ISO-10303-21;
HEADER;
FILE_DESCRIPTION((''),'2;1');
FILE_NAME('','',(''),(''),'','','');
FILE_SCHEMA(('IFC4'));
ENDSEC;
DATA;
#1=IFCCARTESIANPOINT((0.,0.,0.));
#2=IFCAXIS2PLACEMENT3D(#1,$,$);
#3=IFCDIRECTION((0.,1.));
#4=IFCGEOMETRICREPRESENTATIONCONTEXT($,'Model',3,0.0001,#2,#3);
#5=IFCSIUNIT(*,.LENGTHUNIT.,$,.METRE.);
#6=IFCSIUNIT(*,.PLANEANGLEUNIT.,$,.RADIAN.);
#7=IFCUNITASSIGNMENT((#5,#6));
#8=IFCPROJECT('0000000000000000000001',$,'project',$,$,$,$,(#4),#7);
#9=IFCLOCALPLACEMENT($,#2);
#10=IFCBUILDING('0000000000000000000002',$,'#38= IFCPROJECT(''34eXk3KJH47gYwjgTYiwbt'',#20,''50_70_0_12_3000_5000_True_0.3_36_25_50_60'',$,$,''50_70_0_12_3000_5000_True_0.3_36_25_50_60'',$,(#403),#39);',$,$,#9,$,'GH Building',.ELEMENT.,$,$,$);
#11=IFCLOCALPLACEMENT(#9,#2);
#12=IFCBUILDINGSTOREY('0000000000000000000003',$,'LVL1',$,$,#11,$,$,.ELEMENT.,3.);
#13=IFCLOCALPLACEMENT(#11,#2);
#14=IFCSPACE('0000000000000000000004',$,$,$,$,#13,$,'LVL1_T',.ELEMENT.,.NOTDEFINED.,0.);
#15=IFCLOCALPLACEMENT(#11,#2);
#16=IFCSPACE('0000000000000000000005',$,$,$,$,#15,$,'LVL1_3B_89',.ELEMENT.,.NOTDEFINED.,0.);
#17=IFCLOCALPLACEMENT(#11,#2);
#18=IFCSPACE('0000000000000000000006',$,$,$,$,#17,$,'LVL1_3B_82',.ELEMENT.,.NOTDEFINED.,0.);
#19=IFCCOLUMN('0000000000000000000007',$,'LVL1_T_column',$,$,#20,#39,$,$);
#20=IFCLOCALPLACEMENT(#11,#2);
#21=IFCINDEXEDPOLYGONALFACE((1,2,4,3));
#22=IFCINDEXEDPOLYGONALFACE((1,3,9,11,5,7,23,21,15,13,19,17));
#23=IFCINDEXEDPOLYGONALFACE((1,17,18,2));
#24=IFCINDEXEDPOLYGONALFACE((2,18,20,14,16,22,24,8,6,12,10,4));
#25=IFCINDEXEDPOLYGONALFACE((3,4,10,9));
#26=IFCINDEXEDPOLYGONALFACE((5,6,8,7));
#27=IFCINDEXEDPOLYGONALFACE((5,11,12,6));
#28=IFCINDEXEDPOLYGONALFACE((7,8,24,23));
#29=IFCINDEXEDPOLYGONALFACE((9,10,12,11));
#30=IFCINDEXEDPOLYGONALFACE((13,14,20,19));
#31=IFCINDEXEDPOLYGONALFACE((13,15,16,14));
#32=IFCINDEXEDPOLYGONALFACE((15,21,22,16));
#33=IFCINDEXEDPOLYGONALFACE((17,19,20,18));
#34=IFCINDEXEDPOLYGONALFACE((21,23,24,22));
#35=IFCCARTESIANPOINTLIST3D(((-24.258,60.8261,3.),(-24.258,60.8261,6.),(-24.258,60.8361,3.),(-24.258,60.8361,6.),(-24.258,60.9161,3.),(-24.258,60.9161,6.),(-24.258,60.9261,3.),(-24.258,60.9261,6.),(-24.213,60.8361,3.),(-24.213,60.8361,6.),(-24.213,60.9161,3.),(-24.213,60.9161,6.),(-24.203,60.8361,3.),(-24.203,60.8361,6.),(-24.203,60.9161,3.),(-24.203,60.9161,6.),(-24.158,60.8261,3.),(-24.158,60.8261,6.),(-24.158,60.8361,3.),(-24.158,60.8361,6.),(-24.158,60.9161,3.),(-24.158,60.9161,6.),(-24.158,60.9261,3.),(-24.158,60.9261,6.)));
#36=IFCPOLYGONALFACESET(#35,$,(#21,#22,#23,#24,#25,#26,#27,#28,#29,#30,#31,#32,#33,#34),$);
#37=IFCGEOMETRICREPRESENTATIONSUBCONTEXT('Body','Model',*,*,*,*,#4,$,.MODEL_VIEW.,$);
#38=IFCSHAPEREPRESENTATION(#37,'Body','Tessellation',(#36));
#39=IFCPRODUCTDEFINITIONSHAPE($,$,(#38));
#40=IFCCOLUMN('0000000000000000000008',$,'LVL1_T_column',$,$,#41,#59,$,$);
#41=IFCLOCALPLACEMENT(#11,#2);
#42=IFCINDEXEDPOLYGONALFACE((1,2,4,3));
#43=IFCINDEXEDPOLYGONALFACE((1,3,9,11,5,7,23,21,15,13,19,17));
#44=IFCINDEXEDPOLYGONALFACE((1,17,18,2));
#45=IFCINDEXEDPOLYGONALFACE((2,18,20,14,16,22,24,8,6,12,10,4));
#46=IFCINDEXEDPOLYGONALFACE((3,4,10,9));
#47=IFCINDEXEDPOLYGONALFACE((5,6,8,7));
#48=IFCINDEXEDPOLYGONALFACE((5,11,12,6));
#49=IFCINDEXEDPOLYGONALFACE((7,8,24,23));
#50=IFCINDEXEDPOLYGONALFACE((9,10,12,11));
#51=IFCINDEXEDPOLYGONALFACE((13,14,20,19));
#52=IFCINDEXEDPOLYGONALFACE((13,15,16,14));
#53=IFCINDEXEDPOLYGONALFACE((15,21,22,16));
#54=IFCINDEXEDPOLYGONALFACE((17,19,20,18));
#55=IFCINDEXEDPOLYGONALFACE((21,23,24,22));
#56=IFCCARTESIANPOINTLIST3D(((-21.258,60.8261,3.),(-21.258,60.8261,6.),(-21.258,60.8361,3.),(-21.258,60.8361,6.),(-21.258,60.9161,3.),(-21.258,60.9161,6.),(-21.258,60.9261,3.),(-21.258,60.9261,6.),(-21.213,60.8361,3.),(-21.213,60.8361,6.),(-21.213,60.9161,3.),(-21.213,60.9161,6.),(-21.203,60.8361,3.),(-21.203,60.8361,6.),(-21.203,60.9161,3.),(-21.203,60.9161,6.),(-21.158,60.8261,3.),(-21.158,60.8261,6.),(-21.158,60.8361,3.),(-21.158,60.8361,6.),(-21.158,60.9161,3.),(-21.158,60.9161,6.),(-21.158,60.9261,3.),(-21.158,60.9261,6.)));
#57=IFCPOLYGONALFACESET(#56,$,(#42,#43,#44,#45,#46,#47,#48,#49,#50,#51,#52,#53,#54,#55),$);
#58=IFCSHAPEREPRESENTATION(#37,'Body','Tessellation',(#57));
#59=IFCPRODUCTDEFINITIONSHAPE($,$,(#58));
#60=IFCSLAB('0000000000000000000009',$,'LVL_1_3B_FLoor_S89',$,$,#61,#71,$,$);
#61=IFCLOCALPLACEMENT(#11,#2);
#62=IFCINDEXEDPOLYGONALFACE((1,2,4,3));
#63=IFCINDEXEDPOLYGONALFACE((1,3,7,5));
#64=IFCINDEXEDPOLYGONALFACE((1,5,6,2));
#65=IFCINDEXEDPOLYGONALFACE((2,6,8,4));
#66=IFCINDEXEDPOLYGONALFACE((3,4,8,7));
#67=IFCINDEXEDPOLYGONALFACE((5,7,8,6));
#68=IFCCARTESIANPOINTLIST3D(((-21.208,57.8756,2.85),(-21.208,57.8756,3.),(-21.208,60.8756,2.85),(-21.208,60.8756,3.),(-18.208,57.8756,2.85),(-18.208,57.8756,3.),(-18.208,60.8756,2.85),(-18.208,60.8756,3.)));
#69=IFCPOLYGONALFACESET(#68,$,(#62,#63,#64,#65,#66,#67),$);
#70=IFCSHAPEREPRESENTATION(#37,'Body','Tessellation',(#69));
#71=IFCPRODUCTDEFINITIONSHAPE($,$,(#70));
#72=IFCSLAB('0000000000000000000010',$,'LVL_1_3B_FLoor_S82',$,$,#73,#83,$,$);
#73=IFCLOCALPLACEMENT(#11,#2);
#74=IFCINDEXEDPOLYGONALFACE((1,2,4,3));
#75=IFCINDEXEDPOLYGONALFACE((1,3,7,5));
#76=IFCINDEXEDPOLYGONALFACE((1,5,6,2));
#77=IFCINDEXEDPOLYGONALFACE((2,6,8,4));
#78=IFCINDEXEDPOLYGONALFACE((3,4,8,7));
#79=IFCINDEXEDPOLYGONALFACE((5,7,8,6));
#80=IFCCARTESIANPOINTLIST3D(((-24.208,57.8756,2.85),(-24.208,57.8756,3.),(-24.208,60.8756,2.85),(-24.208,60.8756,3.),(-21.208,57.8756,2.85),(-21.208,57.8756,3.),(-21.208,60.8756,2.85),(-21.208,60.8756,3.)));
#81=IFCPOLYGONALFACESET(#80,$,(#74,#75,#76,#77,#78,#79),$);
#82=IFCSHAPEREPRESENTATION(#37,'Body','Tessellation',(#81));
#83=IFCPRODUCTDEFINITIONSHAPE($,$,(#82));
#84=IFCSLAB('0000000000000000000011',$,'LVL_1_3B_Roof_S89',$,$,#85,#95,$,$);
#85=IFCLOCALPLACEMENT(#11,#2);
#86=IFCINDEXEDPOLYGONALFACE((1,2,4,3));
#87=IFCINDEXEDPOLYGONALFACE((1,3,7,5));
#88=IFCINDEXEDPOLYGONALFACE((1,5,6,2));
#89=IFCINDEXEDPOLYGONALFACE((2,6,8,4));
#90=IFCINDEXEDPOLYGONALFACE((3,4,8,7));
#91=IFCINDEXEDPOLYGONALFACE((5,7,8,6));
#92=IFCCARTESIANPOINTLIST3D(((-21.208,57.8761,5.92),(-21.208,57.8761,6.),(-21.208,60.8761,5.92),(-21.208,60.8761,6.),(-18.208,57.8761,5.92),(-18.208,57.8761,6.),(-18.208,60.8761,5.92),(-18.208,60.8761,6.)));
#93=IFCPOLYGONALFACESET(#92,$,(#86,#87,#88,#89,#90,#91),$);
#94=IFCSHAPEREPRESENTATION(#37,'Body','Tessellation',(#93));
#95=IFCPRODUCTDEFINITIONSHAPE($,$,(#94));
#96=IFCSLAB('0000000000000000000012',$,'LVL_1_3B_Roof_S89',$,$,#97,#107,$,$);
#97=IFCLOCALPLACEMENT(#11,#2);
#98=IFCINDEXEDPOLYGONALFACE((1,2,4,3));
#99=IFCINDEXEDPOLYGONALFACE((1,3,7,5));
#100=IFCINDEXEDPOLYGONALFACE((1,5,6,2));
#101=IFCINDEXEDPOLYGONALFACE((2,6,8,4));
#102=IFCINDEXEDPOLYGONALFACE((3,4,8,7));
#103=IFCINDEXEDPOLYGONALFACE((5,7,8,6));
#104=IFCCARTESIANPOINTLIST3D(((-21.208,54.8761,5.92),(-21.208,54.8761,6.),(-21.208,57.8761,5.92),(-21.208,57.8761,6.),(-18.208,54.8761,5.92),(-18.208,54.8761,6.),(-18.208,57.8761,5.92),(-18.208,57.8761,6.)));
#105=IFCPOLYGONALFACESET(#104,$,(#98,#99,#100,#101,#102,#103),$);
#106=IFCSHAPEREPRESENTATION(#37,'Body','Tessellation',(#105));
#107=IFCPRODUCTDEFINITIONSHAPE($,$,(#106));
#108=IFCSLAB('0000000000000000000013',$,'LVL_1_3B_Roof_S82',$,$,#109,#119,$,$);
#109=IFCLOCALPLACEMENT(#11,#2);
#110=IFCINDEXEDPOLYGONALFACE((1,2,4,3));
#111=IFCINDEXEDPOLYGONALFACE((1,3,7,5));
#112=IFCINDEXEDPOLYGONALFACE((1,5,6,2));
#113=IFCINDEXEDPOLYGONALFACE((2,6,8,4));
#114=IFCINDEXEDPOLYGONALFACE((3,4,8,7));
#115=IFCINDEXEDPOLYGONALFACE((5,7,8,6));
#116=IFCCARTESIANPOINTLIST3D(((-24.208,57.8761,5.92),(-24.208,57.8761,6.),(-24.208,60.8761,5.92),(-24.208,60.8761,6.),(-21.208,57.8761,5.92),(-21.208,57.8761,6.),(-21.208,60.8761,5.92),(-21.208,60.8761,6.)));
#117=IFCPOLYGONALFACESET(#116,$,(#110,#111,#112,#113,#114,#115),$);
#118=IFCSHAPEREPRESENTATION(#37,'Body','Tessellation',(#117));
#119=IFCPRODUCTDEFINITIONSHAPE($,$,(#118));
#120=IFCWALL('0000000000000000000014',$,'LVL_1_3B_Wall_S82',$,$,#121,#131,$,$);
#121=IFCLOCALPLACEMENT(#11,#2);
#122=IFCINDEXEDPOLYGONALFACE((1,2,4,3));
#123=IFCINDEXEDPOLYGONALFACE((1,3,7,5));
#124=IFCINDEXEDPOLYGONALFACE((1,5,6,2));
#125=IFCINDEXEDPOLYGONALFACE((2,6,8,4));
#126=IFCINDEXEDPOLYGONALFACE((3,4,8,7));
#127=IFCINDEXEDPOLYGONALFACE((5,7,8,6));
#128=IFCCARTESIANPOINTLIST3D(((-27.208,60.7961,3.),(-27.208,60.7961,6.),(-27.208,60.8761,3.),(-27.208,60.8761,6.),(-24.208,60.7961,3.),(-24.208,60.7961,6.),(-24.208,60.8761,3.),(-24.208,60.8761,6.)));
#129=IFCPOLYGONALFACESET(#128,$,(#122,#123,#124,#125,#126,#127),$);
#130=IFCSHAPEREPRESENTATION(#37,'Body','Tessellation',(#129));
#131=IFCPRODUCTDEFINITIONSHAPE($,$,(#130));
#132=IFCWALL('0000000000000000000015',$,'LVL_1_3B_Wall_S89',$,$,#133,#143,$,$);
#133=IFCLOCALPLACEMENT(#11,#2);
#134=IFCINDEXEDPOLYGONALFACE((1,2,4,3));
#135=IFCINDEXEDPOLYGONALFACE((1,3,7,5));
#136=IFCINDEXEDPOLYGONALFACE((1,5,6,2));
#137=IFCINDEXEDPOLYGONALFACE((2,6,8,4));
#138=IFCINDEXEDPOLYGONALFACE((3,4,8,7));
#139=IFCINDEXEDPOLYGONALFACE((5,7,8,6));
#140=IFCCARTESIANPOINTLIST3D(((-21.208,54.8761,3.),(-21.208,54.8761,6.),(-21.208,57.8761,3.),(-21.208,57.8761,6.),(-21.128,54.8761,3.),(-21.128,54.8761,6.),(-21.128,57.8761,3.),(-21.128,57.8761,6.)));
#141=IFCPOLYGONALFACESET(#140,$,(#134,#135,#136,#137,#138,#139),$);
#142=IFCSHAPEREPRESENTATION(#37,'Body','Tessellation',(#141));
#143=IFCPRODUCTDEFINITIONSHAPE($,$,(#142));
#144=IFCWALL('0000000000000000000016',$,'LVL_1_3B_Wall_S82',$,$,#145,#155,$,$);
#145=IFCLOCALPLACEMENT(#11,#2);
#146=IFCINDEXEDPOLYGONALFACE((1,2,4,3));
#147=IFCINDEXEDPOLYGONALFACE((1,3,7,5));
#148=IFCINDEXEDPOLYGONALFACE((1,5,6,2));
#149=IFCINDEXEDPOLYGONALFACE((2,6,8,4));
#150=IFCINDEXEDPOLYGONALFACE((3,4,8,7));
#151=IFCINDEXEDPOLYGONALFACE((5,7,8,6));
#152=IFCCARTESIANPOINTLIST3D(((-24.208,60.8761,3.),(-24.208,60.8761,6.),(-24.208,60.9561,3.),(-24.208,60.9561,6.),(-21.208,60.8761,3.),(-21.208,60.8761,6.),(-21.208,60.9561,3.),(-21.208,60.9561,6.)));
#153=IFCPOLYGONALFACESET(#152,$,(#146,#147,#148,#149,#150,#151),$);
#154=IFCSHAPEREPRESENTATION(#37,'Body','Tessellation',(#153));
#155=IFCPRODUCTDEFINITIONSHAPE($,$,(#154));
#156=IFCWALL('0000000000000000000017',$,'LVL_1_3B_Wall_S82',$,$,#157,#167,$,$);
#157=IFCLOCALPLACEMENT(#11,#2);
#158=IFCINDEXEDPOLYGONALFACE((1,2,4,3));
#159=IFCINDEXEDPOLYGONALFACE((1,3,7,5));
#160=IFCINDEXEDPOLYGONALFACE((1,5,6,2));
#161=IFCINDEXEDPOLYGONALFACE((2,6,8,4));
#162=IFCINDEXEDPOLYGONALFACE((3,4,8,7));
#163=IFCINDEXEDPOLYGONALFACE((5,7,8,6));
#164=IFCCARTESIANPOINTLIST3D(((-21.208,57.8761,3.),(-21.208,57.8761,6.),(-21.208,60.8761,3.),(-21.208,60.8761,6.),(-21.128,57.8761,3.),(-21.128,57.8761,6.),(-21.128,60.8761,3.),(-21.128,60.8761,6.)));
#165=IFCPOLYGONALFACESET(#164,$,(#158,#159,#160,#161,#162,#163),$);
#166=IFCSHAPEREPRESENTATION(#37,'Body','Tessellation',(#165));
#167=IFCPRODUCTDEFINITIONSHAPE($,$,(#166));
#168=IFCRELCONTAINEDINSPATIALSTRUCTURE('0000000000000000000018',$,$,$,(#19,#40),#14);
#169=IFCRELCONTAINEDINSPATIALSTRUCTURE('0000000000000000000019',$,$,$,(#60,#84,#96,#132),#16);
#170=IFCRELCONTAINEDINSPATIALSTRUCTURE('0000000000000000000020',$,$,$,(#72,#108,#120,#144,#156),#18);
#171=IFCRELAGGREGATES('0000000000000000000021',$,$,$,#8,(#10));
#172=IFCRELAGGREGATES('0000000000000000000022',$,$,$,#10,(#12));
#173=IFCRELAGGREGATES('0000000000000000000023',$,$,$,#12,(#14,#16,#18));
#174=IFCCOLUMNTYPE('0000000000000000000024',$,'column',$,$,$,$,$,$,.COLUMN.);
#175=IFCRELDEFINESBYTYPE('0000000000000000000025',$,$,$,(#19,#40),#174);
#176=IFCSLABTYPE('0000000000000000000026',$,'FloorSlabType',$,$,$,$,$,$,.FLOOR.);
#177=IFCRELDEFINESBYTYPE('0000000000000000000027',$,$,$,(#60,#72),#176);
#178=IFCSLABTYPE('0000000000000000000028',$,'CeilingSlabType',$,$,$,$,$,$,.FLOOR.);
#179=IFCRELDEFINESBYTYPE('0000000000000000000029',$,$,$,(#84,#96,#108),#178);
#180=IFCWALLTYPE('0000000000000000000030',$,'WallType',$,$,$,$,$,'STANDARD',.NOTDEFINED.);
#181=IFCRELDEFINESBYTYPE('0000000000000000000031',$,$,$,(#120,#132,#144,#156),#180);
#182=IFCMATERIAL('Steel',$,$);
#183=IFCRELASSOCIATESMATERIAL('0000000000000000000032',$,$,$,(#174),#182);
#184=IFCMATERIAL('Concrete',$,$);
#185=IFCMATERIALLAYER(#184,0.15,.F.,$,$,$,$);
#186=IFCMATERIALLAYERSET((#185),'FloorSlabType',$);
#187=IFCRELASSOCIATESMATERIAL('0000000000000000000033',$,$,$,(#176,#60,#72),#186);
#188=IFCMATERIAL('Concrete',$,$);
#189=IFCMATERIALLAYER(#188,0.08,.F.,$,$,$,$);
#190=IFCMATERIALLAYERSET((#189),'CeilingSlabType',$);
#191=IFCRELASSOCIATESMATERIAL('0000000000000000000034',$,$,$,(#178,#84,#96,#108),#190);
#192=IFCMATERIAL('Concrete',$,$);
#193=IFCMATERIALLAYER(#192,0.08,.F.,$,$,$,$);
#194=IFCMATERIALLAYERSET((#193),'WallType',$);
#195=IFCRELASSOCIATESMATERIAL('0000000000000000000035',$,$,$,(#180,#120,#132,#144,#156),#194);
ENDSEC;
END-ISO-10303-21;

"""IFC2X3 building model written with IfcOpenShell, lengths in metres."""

from ifc_helpers import new_model, si_unit, direction, frame, frame_2d, origin, origin_2d, place, context, subcontext, project, spatial, rectangle, i_section, extrude, material, layer, layer_set, layer_usage, type_object, element, save


model = new_model("IFC2X3")

# Units and contexts
model_context = context("Model", 3, precision=0.0001, world=origin(), true_north=direction((0.0, 1.0)))
body_context = subcontext(model_context, "Body", "Model", "MODEL_VIEW")
ifc_project = project(units=[si_unit("LENGTHUNIT", "METRE"), si_unit("PLANEANGLEUNIT", "RADIAN")], contexts=[model_context])

# Building, storey, space
building_placement = place(None, origin())
building = spatial("IfcBuilding", under=ifc_project, at=building_placement, Name="#38= IFCPROJECT('34eXk3KJH47gYwjgTYiwbt',#20,'50_70_0_12_3000_5000_True_0.3_36_25_50_60',$,$,'50_70_0_12_3000_5000_True_0.3_36_25_50_60',$,(#403),#39);", LongName="GH Building", CompositionType="ELEMENT")
storey_placement = place(building_placement, origin())
storey = spatial("IfcBuildingStorey", under=building, at=storey_placement, Name="LVL1", CompositionType="ELEMENT", Elevation=3.0)
space_1_placement = place(storey_placement, origin())
space_1 = spatial("IfcSpace", under=storey, at=space_1_placement, LongName="LVL1_T", CompositionType="ELEMENT", InteriorOrExteriorSpace="NOTDEFINED", ElevationWithFlooring=0.0)

# Columns
ifc_material_1 = material(Name="Steel")
column_type = type_object("IfcColumnType", Name="column", PredefinedType="COLUMN", material=ifc_material_1)
for number, where, name in (
    (1, (-24.208, 60.8761, 3.0), "LVL1_T_column"),
    (2, (-21.208, 60.8761, 3.0), "LVL1_T_column"),
):
    element("IfcColumn", number, at=place(space_1_placement, frame(where)), inside=space_1, type_object=column_type, Name=name, context=body_context, shape_type="SweptSolid", body=[
        extrude(i_section(OverallWidth=0.1, OverallDepth=0.1, WebThickness=0.01, FlangeThickness=0.01, at=origin_2d()), origin(), (0.0, 0.0, 1.0), 3.0),
    ])

# Shared definitions
space_2_placement = place(storey_placement, origin())
space_2 = spatial("IfcSpace", under=storey, at=space_2_placement, LongName="LVL1_3B_89", CompositionType="ELEMENT", InteriorOrExteriorSpace="NOTDEFINED", ElevationWithFlooring=0.0)

# Slab
ifc_material_2 = material(Name="Concrete")
ifc_layer_1 = layer(ifc_material_2, 0.15, ventilated=False)
ifc_layer_set_1 = layer_set([ifc_layer_1], Name="FloorSlabType")
ifc_layer_usage_1 = layer_usage(ifc_layer_set_1, "AXIS3", "NEGATIVE", -0.15)
slab_type_1 = type_object("IfcSlabType", Name="FloorSlabType", PredefinedType="FLOOR", material=ifc_layer_set_1)
slab_1_placement = place(space_2_placement, frame((-21.208, 57.8756, 2.85)))
element("IfcSlab", 3, at=slab_1_placement, inside=space_2, type_object=slab_type_1, material=ifc_layer_usage_1, Name="LVL_1_3B_FLoor_S89", context=body_context, shape_type="SweptSolid", body=[
    extrude(rectangle(XDim=3.0, YDim=3.0, at=frame_2d((1.5, 1.5))), origin(), (0.0, 0.0, 1.0), 0.15),
])

# Shared definitions
space_3_placement = place(storey_placement, origin())
space_3 = spatial("IfcSpace", under=storey, at=space_3_placement, LongName="LVL1_3B_82", CompositionType="ELEMENT", InteriorOrExteriorSpace="NOTDEFINED", ElevationWithFlooring=0.0)

# Slabs
ifc_layer_usage_2 = layer_usage(ifc_layer_set_1, "AXIS3", "NEGATIVE", -0.15)
slab_2_placement = place(space_3_placement, frame((-24.208, 57.8756, 2.85)))
element("IfcSlab", 4, at=slab_2_placement, inside=space_3, type_object=slab_type_1, material=ifc_layer_usage_2, Name="LVL_1_3B_FLoor_S82", context=body_context, shape_type="SweptSolid", body=[
    extrude(rectangle(XDim=3.0, YDim=3.0, at=frame_2d((1.5, 1.5))), origin(), (0.0, 0.0, 1.0), 0.15),
])
ifc_material_3 = material(Name="Concrete")
ifc_layer_2 = layer(ifc_material_3, 0.08, ventilated=False)
ifc_layer_set_2 = layer_set([ifc_layer_2], Name="CeilingSlabType")
ifc_layer_usage_3 = layer_usage(ifc_layer_set_2, "AXIS3", "NEGATIVE", -0.08)
slab_type_2 = type_object("IfcSlabType", Name="CeilingSlabType", PredefinedType="FLOOR", material=ifc_layer_set_2)
slab_3_placement = place(space_2_placement, frame((-21.208, 57.8761, 5.92)))
element("IfcSlab", 5, at=slab_3_placement, inside=space_2, type_object=slab_type_2, material=ifc_layer_usage_3, Name="LVL_1_3B_Roof_S89", context=body_context, shape_type="SweptSolid", body=[
    extrude(rectangle(XDim=3.0, YDim=3.0, at=frame_2d((1.5, 1.5))), origin(), (0.0, 0.0, 1.0), 0.08),
])
ifc_layer_usage_4 = layer_usage(ifc_layer_set_2, "AXIS3", "NEGATIVE", -0.08)
slab_4_placement = place(space_2_placement, frame((-21.208, 54.8761, 5.92)))
element("IfcSlab", 6, at=slab_4_placement, inside=space_2, type_object=slab_type_2, material=ifc_layer_usage_4, Name="LVL_1_3B_Roof_S89", context=body_context, shape_type="SweptSolid", body=[
    extrude(rectangle(XDim=3.0, YDim=3.0, at=frame_2d((1.5, 1.5))), origin(), (0.0, 0.0, 1.0), 0.08),
])
ifc_layer_usage_5 = layer_usage(ifc_layer_set_2, "AXIS3", "NEGATIVE", -0.08)
slab_5_placement = place(space_3_placement, frame((-21.208, 57.8761, 5.92), z_axis=(0.0, 0.0, 1.0), x_axis=(-1.0, 0.0, 0.0)))
element("IfcSlab", 7, at=slab_5_placement, inside=space_3, type_object=slab_type_2, material=ifc_layer_usage_5, Name="LVL_1_3B_Roof_S82", context=body_context, shape_type="SweptSolid", body=[
    extrude(rectangle(XDim=3.0, YDim=3.0, at=frame_2d((1.5, -1.5))), origin(), (0.0, 0.0, 1.0), 0.08),
])

# Shared definitions
ifc_material_4 = material(Name="Concrete")
ifc_layer_3 = layer(ifc_material_4, 0.08, ventilated=False)
ifc_layer_set_3 = layer_set([ifc_layer_3], Name="WallType")
wall_type = type_object("IfcWallType", Name="WallType", ElementType="STANDARD", PredefinedType="NOTDEFINED", material=ifc_layer_set_3)

# Walls
ifc_layer_usage_6 = layer_usage(ifc_layer_set_3, "AXIS2", "NEGATIVE", 0.0)
wall_1_placement = place(space_3_placement, frame((-27.208, 60.8761, 3.0)))
element("IfcWall", 8, at=wall_1_placement, inside=space_3, type_object=wall_type, material=ifc_layer_usage_6, Name="LVL_1_3B_Wall_S82", context=body_context, shape_type="SweptSolid", body=[
    extrude(rectangle(XDim=3.0, YDim=0.08, at=frame_2d((1.5, -0.04))), origin(), (0.0, 0.0, 1.0), 3.0),
])
ifc_layer_usage_7 = layer_usage(ifc_layer_set_3, "AXIS2", "NEGATIVE", 0.0)
wall_2_placement = place(space_2_placement, frame((-21.208, 54.8761, 3.0), z_axis=(0.0, 0.0, 1.0), x_axis=(0.0, 1.0, 0.0)))
element("IfcWall", 9, at=wall_2_placement, inside=space_2, type_object=wall_type, material=ifc_layer_usage_7, Name="LVL_1_3B_Wall_S89", context=body_context, shape_type="SweptSolid", body=[
    extrude(rectangle(XDim=3.0, YDim=0.08, at=frame_2d((1.5, -0.04))), origin(), (0.0, 0.0, 1.0), 3.0),
])
ifc_layer_usage_8 = layer_usage(ifc_layer_set_3, "AXIS2", "NEGATIVE", 0.0)
wall_3_placement = place(space_3_placement, frame((-21.208, 60.8761, 3.0), z_axis=(0.0, 0.0, 1.0), x_axis=(-1.0, 0.0, 0.0)))
element("IfcWall", 10, at=wall_3_placement, inside=space_3, type_object=wall_type, material=ifc_layer_usage_8, Name="LVL_1_3B_Wall_S82", context=body_context, shape_type="SweptSolid", body=[
    extrude(rectangle(XDim=3.0, YDim=0.08, at=frame_2d((1.5, -0.04))), origin(), (0.0, 0.0, 1.0), 3.0),
])
ifc_layer_usage_9 = layer_usage(ifc_layer_set_3, "AXIS2", "NEGATIVE", 0.0)
wall_4_placement = place(space_3_placement, frame((-21.208, 57.8761, 3.0), z_axis=(0.0, 0.0, 1.0), x_axis=(0.0, 1.0, 0.0)))
element("IfcWall", 11, at=wall_4_placement, inside=space_3, type_object=wall_type, material=ifc_layer_usage_9, Name="LVL_1_3B_Wall_S82", context=body_context, shape_type="SweptSolid", body=[
    extrude(rectangle(XDim=3.0, YDim=0.08, at=frame_2d((1.5, -0.04))), origin(), (0.0, 0.0, 1.0), 3.0),
])

save(model, "model.ifc")
